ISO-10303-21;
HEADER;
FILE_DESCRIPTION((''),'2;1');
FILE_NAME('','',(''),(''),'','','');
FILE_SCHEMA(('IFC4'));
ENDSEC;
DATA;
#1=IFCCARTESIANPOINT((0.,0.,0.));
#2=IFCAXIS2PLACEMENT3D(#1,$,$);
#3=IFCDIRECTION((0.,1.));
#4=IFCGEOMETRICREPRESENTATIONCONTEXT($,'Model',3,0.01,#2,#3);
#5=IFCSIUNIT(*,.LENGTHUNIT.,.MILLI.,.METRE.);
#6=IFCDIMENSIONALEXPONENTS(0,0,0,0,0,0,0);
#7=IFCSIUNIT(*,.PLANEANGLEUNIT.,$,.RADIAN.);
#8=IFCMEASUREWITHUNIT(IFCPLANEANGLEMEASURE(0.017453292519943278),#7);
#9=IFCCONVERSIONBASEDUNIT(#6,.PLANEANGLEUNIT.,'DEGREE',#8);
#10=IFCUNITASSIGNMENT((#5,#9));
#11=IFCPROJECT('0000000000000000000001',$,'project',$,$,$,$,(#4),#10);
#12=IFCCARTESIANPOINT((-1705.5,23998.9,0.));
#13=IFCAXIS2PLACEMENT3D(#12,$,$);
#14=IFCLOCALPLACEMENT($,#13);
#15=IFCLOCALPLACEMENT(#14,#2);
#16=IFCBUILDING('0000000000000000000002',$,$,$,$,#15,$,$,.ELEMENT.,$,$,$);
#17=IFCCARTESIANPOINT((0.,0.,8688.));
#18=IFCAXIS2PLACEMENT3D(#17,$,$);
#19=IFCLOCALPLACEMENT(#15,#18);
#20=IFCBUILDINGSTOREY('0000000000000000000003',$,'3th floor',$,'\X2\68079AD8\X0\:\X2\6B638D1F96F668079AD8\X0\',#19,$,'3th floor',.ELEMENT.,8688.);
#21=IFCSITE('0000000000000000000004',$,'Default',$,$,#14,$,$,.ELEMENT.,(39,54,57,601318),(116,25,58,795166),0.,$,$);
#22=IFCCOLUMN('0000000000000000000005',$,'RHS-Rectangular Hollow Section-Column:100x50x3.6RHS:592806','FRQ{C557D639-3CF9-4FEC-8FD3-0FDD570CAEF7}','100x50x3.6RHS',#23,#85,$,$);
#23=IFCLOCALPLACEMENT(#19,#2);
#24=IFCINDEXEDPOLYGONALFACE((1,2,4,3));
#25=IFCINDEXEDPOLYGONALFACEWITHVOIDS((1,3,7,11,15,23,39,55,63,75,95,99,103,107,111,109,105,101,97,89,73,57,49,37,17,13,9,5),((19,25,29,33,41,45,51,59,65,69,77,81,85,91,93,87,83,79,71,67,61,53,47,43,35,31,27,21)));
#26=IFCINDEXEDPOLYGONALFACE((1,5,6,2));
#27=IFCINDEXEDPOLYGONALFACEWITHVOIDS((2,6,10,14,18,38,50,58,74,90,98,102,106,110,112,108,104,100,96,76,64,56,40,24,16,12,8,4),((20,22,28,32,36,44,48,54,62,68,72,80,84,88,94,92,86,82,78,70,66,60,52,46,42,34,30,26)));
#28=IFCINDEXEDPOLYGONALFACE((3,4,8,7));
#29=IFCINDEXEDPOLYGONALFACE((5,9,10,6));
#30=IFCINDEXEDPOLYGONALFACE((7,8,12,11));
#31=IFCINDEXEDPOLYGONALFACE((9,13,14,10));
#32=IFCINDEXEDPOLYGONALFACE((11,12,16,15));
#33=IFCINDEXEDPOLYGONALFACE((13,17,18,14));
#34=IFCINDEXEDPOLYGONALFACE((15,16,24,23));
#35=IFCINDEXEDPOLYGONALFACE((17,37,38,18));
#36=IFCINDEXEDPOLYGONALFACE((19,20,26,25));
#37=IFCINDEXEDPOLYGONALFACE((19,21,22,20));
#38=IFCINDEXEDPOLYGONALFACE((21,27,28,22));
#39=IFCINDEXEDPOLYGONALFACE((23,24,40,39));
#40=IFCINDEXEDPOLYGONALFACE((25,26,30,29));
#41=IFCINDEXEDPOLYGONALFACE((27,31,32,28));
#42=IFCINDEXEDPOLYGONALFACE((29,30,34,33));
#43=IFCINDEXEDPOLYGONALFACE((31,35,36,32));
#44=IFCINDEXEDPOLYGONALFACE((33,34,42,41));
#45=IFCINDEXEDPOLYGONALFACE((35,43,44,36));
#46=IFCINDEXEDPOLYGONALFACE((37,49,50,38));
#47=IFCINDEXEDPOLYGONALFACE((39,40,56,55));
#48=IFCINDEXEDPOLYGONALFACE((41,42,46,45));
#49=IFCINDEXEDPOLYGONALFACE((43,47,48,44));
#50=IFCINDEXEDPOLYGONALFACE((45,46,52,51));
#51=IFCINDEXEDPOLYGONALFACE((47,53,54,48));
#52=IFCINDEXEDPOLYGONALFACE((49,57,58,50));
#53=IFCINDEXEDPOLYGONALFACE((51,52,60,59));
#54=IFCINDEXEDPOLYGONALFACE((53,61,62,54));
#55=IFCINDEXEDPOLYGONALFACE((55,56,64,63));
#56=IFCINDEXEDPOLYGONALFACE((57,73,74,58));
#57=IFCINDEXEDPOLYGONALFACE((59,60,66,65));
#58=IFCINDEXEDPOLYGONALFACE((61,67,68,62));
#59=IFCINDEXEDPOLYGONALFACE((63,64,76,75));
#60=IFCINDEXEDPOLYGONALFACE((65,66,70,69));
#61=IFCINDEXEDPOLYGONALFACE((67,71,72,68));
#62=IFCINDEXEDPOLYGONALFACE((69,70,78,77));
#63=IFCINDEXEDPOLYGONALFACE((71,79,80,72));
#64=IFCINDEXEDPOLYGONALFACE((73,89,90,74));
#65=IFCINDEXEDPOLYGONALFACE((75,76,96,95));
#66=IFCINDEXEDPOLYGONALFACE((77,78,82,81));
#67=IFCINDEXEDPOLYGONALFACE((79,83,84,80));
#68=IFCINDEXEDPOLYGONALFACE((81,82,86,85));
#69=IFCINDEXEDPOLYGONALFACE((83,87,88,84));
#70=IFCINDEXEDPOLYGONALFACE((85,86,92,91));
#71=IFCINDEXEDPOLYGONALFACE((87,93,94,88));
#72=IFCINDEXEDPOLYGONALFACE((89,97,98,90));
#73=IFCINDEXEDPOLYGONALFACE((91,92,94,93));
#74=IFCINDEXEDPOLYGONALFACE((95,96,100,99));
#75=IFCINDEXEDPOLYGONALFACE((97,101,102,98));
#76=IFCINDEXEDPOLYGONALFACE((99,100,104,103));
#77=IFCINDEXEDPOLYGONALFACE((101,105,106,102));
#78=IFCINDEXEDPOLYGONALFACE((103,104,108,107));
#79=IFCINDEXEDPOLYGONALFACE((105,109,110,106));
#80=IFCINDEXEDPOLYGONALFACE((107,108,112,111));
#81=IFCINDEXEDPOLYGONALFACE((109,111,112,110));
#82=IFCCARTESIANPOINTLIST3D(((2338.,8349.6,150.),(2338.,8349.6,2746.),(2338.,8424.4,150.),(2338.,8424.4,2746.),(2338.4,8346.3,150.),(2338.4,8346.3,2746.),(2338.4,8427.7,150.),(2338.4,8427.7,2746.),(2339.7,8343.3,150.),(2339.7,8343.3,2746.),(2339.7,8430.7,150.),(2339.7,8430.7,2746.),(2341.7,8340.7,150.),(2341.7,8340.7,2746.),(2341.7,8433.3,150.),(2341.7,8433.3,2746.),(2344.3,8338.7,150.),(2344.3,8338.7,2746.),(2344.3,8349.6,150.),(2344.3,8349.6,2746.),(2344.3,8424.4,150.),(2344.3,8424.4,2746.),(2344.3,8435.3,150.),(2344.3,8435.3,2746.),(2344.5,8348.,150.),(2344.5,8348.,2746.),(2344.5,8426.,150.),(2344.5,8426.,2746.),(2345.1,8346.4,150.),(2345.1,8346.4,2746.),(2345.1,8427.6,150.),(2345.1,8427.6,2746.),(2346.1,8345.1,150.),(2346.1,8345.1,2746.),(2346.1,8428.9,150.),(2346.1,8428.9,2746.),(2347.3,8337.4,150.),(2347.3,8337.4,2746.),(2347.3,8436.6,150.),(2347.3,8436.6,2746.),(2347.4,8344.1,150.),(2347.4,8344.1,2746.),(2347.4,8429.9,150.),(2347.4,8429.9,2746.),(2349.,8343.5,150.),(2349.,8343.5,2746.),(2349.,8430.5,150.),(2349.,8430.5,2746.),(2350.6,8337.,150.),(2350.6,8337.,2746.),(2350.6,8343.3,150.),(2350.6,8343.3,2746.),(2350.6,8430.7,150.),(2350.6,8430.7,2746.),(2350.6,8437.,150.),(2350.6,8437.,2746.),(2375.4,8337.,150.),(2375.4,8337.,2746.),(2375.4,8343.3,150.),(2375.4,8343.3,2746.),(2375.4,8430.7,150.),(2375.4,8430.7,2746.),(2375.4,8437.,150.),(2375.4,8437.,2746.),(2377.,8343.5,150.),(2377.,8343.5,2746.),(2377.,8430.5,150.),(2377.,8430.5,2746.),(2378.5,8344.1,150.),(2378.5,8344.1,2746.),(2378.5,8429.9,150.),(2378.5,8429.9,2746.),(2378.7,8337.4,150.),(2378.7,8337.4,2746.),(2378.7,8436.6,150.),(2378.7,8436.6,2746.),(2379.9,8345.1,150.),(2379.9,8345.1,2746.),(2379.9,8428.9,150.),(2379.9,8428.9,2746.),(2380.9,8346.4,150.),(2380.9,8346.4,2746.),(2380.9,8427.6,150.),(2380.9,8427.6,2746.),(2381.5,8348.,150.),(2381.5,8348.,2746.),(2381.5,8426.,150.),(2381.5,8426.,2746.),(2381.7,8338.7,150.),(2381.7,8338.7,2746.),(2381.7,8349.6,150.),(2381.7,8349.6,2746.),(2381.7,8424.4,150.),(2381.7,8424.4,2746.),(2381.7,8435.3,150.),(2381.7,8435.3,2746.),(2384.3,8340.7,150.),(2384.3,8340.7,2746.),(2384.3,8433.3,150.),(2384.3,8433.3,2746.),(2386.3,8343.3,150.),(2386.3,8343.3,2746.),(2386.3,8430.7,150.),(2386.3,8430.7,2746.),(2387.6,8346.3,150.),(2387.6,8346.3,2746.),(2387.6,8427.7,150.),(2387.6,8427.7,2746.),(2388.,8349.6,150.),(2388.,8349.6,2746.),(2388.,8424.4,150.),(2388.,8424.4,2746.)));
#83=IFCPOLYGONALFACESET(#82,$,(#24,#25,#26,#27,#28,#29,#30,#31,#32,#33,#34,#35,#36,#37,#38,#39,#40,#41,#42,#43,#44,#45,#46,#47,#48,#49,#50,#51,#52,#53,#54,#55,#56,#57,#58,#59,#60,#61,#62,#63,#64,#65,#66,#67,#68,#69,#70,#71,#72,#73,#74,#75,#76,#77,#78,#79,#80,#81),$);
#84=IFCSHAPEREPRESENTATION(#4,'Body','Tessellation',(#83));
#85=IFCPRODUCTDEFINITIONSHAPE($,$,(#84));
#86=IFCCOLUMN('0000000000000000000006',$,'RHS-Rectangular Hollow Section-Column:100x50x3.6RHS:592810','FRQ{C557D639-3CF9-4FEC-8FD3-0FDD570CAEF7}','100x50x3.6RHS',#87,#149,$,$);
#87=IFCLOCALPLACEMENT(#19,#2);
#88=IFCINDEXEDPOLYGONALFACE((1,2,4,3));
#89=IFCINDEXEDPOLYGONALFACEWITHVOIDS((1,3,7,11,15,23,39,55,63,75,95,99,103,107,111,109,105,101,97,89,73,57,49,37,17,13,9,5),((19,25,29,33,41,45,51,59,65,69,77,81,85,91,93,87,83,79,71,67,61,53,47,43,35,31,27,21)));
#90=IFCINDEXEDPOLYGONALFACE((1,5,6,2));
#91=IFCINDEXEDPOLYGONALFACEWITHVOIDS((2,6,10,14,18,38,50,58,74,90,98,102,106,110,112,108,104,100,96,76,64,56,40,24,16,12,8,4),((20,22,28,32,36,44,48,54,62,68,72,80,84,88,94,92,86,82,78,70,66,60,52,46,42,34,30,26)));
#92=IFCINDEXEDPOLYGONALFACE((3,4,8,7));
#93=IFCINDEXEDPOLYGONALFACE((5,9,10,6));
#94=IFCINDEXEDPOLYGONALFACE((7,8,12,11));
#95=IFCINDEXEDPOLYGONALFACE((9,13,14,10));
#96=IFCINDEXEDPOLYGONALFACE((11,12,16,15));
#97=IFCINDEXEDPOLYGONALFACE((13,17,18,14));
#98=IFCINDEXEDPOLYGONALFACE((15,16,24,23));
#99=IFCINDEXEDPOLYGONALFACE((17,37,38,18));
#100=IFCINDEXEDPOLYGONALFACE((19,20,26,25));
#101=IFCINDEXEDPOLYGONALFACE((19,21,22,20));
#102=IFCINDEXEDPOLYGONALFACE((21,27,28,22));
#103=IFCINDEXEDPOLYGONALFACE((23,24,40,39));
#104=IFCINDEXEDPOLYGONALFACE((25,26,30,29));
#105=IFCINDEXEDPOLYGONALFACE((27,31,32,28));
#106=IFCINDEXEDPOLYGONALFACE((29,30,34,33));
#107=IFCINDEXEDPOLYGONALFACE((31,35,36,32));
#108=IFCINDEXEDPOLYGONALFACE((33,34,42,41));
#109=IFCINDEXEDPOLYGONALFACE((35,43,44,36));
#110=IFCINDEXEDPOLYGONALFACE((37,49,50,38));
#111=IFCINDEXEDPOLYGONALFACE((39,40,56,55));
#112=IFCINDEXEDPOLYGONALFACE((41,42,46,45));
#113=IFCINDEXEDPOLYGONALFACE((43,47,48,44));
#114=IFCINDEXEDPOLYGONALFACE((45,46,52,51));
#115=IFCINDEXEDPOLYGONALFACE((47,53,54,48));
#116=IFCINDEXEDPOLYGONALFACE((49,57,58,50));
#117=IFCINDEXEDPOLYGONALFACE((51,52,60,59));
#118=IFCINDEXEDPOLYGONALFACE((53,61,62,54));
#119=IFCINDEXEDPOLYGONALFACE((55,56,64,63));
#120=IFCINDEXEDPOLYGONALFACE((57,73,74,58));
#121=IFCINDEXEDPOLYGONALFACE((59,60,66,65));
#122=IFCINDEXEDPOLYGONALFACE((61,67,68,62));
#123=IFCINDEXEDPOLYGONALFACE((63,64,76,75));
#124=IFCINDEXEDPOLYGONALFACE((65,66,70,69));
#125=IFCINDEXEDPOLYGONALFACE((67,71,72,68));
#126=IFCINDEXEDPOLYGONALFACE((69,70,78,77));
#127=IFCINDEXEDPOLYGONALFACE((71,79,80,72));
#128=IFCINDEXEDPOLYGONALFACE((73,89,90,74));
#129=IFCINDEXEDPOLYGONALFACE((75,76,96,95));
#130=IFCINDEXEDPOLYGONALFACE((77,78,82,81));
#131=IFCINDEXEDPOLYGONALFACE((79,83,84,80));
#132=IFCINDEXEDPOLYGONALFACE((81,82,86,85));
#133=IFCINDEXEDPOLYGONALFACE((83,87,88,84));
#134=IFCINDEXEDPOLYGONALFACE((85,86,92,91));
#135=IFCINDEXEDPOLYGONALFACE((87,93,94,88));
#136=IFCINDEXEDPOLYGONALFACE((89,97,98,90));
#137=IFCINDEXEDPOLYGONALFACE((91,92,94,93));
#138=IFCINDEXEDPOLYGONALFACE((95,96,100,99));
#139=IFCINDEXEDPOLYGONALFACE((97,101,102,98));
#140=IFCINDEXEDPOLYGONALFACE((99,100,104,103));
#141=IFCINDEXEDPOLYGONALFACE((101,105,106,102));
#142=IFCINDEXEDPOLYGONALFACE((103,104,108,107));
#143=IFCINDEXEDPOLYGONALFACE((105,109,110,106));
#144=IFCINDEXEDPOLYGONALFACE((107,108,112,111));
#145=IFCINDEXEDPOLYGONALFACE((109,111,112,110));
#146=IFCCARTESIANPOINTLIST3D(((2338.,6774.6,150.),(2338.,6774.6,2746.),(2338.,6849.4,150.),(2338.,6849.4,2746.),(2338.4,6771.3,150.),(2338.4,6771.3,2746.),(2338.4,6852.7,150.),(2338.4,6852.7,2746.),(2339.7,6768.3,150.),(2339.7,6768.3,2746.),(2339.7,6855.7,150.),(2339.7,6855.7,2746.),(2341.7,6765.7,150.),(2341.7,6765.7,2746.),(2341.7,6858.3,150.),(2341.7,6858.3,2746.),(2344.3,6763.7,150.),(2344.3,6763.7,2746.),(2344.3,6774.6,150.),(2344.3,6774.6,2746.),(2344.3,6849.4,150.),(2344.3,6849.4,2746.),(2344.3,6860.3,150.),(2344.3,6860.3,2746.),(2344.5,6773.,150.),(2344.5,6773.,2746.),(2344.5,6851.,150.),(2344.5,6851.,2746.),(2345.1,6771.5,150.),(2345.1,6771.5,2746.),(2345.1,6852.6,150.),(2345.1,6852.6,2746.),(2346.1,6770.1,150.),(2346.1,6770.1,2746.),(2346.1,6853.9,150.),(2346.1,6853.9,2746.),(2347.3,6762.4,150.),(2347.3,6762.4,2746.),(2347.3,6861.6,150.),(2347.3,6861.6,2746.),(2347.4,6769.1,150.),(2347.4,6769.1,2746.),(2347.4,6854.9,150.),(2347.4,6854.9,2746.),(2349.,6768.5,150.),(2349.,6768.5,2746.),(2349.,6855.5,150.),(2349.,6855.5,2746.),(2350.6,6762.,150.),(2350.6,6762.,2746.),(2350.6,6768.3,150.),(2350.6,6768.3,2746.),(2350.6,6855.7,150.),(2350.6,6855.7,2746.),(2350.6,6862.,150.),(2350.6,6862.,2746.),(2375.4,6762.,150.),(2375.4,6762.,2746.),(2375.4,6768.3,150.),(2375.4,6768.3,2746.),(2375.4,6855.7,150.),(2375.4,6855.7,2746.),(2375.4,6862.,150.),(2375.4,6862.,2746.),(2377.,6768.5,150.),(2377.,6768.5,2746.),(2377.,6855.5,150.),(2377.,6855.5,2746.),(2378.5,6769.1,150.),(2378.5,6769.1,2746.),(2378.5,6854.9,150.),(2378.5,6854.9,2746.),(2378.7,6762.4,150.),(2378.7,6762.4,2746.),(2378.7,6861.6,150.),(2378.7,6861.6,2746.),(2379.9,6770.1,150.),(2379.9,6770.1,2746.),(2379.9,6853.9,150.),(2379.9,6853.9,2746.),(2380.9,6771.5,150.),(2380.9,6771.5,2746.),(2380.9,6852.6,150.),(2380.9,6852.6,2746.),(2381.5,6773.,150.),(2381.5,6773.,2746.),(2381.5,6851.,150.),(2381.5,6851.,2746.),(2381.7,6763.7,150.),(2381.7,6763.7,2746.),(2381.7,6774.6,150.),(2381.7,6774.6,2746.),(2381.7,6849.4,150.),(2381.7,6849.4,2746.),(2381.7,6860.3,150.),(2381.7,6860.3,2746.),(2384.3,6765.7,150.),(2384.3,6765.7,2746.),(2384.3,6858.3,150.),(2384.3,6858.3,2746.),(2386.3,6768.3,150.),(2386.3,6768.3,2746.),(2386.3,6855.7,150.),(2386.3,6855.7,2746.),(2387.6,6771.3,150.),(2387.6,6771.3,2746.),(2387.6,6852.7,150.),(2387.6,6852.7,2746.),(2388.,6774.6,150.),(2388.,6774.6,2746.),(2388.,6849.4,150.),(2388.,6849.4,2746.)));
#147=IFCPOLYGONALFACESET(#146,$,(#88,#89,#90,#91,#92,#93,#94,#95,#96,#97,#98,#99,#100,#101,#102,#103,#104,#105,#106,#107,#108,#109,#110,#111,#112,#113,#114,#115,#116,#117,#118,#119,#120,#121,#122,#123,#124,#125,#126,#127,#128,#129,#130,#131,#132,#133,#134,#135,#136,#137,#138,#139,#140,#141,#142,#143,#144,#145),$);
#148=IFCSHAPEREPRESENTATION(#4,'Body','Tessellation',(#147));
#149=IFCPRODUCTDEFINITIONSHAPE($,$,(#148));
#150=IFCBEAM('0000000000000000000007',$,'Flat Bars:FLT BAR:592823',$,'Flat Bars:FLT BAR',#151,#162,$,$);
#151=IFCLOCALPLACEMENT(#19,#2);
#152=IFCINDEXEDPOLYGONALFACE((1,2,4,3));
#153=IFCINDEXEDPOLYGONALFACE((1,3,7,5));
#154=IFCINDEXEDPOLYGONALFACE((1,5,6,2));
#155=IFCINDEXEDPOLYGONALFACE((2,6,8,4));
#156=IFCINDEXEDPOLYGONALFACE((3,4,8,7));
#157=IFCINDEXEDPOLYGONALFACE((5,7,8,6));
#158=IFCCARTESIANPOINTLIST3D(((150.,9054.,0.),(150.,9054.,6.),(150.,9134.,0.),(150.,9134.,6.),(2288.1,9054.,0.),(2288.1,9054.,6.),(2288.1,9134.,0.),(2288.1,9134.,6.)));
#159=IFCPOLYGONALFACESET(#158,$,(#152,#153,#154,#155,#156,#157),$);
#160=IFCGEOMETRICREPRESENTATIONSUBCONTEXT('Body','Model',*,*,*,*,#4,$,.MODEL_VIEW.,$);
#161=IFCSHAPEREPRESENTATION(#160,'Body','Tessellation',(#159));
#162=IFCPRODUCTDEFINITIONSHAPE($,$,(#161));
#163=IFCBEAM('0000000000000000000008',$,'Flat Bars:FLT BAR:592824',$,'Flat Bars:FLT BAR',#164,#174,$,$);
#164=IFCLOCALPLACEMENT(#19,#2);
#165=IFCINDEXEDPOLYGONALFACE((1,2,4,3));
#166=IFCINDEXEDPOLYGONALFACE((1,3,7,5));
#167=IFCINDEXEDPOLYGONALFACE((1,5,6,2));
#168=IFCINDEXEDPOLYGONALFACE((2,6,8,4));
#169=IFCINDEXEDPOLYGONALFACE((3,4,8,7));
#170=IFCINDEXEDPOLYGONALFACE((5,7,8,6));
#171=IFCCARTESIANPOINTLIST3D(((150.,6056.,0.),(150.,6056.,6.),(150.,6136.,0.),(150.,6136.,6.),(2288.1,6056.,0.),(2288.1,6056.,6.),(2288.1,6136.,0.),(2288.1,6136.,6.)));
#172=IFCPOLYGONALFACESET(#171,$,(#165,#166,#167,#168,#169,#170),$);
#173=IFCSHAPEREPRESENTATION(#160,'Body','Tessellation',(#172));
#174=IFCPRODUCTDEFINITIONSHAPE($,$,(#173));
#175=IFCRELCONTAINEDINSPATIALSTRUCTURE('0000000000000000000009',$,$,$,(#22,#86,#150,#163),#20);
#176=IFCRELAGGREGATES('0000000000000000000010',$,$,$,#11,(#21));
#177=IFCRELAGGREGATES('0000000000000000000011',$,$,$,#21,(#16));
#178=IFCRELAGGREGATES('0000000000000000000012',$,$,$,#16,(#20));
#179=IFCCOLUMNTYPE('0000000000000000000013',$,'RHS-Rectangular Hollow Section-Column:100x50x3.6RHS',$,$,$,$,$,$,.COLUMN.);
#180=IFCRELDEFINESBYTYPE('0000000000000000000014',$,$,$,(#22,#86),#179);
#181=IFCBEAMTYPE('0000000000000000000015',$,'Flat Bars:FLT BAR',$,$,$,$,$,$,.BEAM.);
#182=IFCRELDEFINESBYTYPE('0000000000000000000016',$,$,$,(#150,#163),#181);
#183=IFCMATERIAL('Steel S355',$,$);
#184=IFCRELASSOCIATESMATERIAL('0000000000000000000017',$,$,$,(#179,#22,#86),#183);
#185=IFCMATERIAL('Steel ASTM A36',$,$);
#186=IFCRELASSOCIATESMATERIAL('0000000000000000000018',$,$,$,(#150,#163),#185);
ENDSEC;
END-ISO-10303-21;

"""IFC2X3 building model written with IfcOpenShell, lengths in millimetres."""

from ifc_helpers import new_model, entity, si_unit, converted_unit, direction, frame, origin, origin_2d, origin_2d_with_axis, place, context, subcontext, project, spatial, rectangle, hollow_rectangle, extrude, clip, halfspace, material, type_object, element, save


model = new_model("IFC2X3")

# Units and contexts
model_context = context("Model", 3, precision=0.01, world=origin(), true_north=direction((0.0, 1.0)))
body_context = subcontext(model_context, "Body", "Model", "MODEL_VIEW")
ifc_project = project(units=[si_unit("LENGTHUNIT", "METRE", prefix="MILLI"), converted_unit("PLANEANGLEUNIT", "DEGREE", entity("IfcPlaneAngleMeasure", 0.017453292519943278), si_unit("PLANEANGLEUNIT", "RADIAN"), dimensions=[0, 0, 0, 0, 0, 0, 0])], contexts=[model_context])

# Site, building, storey
site_placement = place(None, frame((-1705.5, 23998.9, 0.0)))
site = spatial("IfcSite", under=ifc_project, at=site_placement, Name="Default", CompositionType="ELEMENT", RefLatitude=(39, 54, 57, 601318), RefLongitude=(116, 25, 58, 795166), RefElevation=0.0)
building_placement = place(site_placement, origin())
building = spatial("IfcBuilding", under=site, at=building_placement, CompositionType="ELEMENT")
storey_placement = place(building_placement, frame((0.0, 0.0, 8688.0)))
storey = spatial("IfcBuildingStorey", under=building, at=storey_placement, Name="3th floor", ObjectType="标高:正负零标高", LongName="3th floor", CompositionType="ELEMENT", Elevation=8688.0)

# Shared definitions
ifc_material_1 = material(Name="Steel S355")

# Columns
column_type_1 = type_object("IfcColumnType", Name="RHS-Rectangular Hollow Section-Column:100x50x3.6RHS", PredefinedType="COLUMN", material=ifc_material_1)
column_1_placement = place(storey_placement, frame((2363.0, 8387.0, 2746.0), z_axis=(0.0, 0.0, 1.0), x_axis=(-1.0, 0.0, 0.0)))
element("IfcColumn", 1, at=column_1_placement, inside=storey, type_object=column_type_1, material=ifc_material_1, Name="RHS-Rectangular Hollow Section-Column:100x50x3.6RHS:592806", Description="FRQ{C557D639-3CF9-4FEC-8FD3-0FDD570CAEF7}", ObjectType="100x50x3.6RHS", context=model_context, shape_type="Clipping", body=[
    clip(extrude(hollow_rectangle(XDim=50.0, YDim=100.0, WallThickness=6.3, InnerFilletRadius=6.3, OuterFilletRadius=12.6, at=origin_2d()), origin(), (0.0, 0.0, -1.0), 2651.9), halfspace(frame((2363.0, 8387.0, -2596.0), z_axis=(0.0, 0.0, 1.0), x_axis=(-1.0, 0.0, 0.0)), True)),
])
column_2_placement = place(storey_placement, frame((2363.0, 6812.0, 2746.0), z_axis=(0.0, 0.0, 1.0), x_axis=(-1.0, 0.0, 0.0)))
element("IfcColumn", 2, at=column_2_placement, inside=storey, type_object=column_type_1, material=ifc_material_1, Name="RHS-Rectangular Hollow Section-Column:100x50x3.6RHS:592810", Description="FRQ{C557D639-3CF9-4FEC-8FD3-0FDD570CAEF7}", ObjectType="100x50x3.6RHS", context=model_context, shape_type="Clipping", body=[
    clip(extrude(hollow_rectangle(XDim=50.0, YDim=100.0, WallThickness=6.3, InnerFilletRadius=6.3, OuterFilletRadius=12.6, at=origin_2d()), origin(), (0.0, 0.0, -1.0), 2651.9), halfspace(frame((2363.0, 6812.0, -2596.0), z_axis=(0.0, 0.0, 1.0), x_axis=(-1.0, 0.0, 0.0)), True)),
])

# Beams
ifc_material_2 = material(Name="Steel ASTM A36")
beam_type = type_object("IfcBeamType", Name="Flat Bars:FLT BAR", PredefinedType="BEAM")
for number, where, name in (
    (3, (150.0, 9094.0, 6.0), "Flat Bars:FLT BAR:592823"),
    (4, (150.0, 6096.0, 6.0), "Flat Bars:FLT BAR:592824"),
):
    element("IfcBeam", number, at=place(storey_placement, frame(where)), inside=storey, type_object=beam_type, material=ifc_material_2, Name=name, ObjectType="Flat Bars:FLT BAR", context=body_context, shape_type="SweptSolid", body=[
        extrude(rectangle(XDim=6.0, YDim=80.0, at=origin_2d_with_axis()), frame((0.0, 0.0, -3.0), z_axis=(1.0, 0.0, 0.0), x_axis=(0.0, 0.0, -1.0)), (0.0, 0.0, 1.0), 2138.1),
    ])

save(model, "model.ifc")
